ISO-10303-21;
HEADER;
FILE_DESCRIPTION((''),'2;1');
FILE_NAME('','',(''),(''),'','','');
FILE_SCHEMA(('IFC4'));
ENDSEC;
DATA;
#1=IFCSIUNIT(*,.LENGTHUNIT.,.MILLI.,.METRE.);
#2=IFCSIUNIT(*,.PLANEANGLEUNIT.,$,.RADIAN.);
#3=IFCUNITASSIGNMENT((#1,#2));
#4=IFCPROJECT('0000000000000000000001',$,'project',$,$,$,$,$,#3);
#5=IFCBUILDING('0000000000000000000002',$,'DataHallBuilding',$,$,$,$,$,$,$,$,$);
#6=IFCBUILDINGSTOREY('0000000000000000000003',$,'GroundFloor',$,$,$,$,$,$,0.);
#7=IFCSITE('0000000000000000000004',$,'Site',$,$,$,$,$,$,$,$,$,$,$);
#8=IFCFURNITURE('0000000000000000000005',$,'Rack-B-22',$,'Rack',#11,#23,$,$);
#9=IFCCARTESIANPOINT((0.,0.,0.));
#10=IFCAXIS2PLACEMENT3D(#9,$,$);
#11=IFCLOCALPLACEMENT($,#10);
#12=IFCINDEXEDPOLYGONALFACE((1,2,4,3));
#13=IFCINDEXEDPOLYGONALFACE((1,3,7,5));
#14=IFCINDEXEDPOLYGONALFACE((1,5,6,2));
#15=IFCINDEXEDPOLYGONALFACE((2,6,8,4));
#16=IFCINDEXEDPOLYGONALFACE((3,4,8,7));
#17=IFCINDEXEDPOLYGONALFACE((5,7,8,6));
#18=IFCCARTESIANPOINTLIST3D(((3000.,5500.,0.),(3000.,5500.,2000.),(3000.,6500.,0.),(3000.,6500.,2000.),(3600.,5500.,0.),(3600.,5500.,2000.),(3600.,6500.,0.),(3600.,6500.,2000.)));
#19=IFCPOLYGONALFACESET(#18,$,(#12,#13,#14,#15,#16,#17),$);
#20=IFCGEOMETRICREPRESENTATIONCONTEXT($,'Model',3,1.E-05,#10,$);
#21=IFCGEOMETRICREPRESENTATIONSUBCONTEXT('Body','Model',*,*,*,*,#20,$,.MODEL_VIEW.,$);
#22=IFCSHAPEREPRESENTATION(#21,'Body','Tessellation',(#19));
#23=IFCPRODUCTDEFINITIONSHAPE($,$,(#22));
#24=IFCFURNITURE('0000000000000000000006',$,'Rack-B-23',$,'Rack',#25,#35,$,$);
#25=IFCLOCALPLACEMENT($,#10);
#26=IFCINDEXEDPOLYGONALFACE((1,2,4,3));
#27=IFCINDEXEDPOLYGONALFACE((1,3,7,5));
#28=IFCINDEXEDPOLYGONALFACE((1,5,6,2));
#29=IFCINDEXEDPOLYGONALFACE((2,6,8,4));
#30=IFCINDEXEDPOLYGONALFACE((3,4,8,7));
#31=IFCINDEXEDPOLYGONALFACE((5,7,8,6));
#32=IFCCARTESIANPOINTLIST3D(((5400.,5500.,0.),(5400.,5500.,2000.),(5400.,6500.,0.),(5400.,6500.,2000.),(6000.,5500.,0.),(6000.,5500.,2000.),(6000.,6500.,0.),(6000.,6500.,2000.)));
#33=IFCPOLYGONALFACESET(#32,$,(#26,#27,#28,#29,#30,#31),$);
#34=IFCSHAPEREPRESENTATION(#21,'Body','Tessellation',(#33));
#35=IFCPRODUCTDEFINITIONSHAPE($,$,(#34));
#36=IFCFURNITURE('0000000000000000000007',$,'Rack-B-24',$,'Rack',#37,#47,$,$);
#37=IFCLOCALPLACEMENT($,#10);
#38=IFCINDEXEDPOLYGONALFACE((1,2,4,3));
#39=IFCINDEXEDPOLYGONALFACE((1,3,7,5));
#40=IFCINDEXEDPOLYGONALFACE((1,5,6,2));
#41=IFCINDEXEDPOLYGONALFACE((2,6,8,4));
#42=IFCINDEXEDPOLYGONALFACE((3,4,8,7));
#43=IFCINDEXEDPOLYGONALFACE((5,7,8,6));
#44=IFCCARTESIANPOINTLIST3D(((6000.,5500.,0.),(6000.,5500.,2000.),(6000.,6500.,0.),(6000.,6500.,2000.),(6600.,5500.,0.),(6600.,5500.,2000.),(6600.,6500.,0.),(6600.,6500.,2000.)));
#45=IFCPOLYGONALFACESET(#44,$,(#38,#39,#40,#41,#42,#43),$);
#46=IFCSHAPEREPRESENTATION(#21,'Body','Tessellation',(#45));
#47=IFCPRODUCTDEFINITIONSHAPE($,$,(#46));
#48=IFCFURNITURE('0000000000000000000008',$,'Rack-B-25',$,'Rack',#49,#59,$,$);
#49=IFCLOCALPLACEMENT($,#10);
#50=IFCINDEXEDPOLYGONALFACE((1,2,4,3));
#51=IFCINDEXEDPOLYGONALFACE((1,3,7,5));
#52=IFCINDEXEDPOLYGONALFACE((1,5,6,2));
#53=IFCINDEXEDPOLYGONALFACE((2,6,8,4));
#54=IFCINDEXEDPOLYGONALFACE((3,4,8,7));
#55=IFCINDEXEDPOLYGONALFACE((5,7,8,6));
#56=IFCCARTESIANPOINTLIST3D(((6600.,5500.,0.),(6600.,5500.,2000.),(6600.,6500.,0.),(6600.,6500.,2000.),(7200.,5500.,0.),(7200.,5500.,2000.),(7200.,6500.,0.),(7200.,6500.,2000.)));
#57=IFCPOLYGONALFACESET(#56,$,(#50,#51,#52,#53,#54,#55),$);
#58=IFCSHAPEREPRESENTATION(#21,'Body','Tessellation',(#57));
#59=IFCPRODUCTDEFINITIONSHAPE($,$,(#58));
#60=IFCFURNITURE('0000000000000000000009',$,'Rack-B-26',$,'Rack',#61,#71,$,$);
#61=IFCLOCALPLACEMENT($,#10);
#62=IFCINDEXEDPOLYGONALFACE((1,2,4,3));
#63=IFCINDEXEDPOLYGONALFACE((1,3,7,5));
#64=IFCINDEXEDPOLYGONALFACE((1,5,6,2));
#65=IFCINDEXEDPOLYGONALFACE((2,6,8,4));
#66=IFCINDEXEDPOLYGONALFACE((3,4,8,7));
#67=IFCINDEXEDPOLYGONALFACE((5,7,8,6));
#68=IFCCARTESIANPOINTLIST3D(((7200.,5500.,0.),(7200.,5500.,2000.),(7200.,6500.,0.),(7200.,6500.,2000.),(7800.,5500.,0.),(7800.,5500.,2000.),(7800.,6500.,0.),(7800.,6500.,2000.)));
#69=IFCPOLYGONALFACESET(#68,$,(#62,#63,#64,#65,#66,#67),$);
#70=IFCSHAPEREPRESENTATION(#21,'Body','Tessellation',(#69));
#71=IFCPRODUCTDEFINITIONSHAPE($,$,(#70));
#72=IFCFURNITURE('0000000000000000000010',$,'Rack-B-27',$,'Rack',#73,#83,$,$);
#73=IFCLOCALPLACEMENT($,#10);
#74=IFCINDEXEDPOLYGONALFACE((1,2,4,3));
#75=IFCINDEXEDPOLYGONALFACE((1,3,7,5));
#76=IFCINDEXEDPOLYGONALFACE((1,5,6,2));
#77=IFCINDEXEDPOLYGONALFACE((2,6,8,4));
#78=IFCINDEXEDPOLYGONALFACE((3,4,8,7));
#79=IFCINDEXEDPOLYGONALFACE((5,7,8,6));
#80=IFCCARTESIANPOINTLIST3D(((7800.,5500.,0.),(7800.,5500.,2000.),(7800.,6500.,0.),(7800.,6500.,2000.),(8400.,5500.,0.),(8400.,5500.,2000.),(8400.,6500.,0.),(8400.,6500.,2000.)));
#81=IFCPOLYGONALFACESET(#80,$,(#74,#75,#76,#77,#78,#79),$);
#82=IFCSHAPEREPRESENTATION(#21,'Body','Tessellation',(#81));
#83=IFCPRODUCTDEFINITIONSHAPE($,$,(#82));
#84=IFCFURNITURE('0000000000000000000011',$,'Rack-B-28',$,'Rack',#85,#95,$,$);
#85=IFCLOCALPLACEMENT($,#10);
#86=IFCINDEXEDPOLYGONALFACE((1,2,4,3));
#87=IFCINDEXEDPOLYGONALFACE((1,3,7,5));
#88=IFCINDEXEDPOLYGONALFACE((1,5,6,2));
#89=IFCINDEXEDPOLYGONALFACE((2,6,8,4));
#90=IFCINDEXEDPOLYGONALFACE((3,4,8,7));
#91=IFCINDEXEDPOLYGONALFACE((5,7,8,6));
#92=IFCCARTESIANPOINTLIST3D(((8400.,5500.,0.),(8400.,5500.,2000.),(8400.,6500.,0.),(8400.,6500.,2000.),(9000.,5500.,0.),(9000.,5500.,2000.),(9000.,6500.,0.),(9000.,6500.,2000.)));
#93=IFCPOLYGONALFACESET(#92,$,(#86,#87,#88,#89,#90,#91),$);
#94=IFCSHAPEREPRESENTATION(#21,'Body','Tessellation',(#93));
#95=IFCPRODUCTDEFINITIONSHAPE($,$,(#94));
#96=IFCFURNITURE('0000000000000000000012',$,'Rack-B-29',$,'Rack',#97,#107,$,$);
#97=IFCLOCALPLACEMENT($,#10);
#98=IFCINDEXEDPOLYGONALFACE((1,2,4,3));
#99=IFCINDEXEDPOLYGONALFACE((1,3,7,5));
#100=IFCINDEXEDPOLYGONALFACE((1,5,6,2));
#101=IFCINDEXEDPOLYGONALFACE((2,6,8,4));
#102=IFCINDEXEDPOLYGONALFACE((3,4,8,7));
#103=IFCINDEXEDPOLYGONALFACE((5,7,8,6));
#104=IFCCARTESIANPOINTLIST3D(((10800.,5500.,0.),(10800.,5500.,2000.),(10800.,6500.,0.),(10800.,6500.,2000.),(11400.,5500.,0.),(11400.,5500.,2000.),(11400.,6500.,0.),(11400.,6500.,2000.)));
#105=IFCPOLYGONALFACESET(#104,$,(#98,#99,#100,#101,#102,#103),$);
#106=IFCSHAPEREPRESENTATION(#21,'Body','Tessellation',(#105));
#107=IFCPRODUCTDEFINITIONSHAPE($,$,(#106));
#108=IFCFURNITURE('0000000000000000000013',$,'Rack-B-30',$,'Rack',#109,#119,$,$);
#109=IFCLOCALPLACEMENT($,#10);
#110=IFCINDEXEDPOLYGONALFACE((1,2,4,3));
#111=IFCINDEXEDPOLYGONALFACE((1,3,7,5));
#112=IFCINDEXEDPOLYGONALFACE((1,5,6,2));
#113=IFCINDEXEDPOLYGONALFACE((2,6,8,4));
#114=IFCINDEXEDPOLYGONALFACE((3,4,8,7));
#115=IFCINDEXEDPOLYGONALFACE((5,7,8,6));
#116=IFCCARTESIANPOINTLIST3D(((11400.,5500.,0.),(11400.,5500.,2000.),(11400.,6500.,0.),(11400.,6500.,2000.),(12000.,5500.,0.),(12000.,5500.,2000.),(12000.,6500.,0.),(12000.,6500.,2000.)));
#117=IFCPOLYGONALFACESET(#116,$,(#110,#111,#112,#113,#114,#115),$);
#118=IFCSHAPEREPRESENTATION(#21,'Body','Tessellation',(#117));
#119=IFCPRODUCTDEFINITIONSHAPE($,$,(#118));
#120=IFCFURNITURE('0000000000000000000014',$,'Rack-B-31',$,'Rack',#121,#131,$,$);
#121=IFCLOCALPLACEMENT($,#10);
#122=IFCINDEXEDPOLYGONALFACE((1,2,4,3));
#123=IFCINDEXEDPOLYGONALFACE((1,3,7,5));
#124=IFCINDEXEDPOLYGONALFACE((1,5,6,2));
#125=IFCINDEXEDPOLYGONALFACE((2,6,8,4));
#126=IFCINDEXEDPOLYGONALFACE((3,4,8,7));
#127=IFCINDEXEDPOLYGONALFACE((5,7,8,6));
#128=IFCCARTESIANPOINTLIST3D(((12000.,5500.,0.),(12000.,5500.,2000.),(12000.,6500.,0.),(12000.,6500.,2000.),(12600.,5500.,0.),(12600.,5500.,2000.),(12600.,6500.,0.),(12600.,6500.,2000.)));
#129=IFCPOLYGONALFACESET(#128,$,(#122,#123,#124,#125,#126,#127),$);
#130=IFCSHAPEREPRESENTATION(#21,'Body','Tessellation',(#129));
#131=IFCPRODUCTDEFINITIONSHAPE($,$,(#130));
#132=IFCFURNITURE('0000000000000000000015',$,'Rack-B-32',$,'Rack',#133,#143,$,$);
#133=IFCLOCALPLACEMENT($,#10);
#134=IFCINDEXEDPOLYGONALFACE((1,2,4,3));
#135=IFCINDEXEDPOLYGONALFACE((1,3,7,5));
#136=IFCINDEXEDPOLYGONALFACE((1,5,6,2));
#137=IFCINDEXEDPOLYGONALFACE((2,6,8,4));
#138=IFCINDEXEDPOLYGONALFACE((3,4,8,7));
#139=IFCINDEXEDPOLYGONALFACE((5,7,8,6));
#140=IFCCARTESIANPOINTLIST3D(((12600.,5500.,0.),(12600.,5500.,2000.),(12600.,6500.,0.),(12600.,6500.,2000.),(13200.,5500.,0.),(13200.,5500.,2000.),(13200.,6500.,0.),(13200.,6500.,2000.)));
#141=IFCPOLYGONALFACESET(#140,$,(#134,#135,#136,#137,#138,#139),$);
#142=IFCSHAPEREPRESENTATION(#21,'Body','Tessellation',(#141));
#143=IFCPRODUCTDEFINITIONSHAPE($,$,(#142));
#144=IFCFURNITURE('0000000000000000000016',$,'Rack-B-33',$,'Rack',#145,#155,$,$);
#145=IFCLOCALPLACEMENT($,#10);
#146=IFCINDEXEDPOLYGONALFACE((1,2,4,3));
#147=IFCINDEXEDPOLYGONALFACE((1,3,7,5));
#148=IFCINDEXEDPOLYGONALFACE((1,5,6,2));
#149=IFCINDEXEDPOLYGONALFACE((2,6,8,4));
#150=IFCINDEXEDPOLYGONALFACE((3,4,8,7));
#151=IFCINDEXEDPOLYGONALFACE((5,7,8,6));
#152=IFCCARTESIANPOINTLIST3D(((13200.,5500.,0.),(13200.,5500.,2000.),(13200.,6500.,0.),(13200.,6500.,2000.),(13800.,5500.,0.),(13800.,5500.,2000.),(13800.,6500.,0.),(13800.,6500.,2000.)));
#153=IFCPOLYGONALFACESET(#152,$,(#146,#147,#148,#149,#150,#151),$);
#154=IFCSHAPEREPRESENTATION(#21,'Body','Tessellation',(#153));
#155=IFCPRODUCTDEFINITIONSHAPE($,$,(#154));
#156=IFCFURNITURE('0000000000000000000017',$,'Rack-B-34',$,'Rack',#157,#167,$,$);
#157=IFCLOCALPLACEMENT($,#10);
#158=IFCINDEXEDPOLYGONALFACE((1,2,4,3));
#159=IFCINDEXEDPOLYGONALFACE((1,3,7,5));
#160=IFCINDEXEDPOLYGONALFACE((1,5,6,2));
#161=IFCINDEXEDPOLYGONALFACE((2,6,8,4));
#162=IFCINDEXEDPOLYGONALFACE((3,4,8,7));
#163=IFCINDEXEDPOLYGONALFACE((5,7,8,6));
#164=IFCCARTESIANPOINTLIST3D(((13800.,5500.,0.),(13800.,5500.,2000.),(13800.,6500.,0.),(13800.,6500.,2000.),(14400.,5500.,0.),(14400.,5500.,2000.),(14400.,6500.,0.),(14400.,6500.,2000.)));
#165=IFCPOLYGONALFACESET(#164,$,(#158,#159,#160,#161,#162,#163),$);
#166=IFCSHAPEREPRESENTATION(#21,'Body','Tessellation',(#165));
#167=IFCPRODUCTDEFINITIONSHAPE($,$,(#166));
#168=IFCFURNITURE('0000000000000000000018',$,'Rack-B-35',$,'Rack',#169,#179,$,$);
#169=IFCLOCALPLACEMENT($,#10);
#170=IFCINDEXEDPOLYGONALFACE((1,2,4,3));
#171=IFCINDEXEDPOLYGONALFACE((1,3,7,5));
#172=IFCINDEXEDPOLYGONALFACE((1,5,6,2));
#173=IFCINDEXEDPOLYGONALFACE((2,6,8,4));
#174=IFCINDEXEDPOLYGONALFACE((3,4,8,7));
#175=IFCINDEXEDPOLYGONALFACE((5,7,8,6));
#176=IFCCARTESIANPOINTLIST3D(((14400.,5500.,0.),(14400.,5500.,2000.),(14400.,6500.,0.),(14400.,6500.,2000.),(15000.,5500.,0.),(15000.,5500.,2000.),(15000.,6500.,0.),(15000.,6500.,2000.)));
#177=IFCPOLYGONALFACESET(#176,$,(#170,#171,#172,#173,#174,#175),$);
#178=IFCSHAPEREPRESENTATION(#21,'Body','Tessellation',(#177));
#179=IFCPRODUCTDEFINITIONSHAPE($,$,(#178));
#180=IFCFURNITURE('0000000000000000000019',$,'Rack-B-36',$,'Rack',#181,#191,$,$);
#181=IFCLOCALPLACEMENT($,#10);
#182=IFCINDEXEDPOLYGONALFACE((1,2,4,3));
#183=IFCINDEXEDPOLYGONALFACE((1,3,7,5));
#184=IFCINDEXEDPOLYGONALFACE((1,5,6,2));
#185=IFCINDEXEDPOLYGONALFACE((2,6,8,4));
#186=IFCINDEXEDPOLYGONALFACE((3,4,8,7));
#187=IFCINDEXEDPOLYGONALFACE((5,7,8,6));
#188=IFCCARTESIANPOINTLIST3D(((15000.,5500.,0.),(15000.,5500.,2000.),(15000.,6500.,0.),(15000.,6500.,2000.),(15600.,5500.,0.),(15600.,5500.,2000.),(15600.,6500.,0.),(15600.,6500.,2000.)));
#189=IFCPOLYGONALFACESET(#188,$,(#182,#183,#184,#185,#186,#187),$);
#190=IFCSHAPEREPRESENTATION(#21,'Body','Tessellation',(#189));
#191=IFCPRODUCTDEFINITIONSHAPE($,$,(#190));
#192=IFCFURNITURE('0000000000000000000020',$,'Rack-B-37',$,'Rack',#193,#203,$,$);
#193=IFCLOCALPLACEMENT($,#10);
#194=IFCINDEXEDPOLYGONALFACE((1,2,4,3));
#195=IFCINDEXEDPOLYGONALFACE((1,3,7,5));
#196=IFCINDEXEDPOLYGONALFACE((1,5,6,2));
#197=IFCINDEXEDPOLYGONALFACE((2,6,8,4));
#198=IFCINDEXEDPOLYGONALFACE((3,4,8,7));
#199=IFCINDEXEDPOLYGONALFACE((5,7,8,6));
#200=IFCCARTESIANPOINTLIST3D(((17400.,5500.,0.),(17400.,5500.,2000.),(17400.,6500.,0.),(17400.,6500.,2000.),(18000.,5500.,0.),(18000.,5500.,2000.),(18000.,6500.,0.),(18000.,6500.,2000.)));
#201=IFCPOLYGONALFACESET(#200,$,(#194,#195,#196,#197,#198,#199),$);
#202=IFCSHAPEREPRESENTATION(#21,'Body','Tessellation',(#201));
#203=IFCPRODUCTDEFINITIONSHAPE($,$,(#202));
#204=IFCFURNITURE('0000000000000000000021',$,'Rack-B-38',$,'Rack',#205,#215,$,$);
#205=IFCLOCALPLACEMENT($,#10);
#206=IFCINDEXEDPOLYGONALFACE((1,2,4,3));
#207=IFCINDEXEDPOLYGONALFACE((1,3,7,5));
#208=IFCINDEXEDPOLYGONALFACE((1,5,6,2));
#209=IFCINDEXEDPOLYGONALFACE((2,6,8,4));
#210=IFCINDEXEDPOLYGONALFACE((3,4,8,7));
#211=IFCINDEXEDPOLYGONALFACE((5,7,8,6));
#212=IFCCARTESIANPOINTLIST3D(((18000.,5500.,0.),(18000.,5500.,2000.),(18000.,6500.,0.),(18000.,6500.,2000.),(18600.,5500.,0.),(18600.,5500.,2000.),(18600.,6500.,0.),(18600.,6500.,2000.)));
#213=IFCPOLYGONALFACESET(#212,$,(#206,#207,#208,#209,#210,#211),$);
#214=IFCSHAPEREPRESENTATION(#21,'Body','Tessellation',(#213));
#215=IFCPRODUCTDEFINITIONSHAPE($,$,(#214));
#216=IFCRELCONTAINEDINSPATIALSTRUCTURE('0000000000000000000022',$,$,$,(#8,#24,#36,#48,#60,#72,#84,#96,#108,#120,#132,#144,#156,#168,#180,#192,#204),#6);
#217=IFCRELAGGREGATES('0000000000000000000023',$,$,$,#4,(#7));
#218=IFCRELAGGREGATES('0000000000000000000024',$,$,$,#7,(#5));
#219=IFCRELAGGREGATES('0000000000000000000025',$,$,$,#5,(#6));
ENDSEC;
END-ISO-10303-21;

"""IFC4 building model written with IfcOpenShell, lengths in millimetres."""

from ifc_helpers import new_model, si_unit, frame, origin, place, context, subcontext, project, spatial, rectangle, extrude, element, save


model = new_model("IFC4")

# Units and contexts
model_context = context("Model", 3, precision=1e-05, world=origin())
body_context = subcontext(model_context, "Body", "Model", "MODEL_VIEW")
ifc_project = project(units=[si_unit("LENGTHUNIT", "METRE", prefix="MILLI"), si_unit("PLANEANGLEUNIT", "RADIAN")])

# Site, building, storey
site = spatial("IfcSite", under=ifc_project, Name="Site")
building = spatial("IfcBuilding", under=site, Name="DataHallBuilding")
storey = spatial("IfcBuildingStorey", under=building, Name="GroundFloor", Elevation=0.0)

# Furniture
furniture_1_placement = place(None, origin())
element("IfcFurniture", 1, at=furniture_1_placement, inside=storey, Name="Rack-B-22", ObjectType="Rack", context=body_context, shape_type="SweptSolid", body=[
    extrude(rectangle(XDim=600.0, YDim=1000.0), frame((3300.0, 6000.0, 0.0), z_axis=(0.0, 0.0, 1.0), x_axis=(1.0, 0.0, 0.0)), (0.0, 0.0, 1.0), 2000.0),
])
furniture_2_placement = place(None, origin())
element("IfcFurniture", 2, at=furniture_2_placement, inside=storey, Name="Rack-B-23", ObjectType="Rack", context=body_context, shape_type="SweptSolid", body=[
    extrude(rectangle(XDim=600.0, YDim=1000.0), frame((5700.0, 6000.0, 0.0), z_axis=(0.0, 0.0, 1.0), x_axis=(1.0, 0.0, 0.0)), (0.0, 0.0, 1.0), 2000.0),
])
furniture_3_placement = place(None, origin())
element("IfcFurniture", 3, at=furniture_3_placement, inside=storey, Name="Rack-B-24", ObjectType="Rack", context=body_context, shape_type="SweptSolid", body=[
    extrude(rectangle(XDim=600.0, YDim=1000.0), frame((6300.0, 6000.0, 0.0), z_axis=(0.0, 0.0, 1.0), x_axis=(1.0, 0.0, 0.0)), (0.0, 0.0, 1.0), 2000.0),
])
furniture_4_placement = place(None, origin())
element("IfcFurniture", 4, at=furniture_4_placement, inside=storey, Name="Rack-B-25", ObjectType="Rack", context=body_context, shape_type="SweptSolid", body=[
    extrude(rectangle(XDim=600.0, YDim=1000.0), frame((6900.0, 6000.0, 0.0), z_axis=(0.0, 0.0, 1.0), x_axis=(1.0, 0.0, 0.0)), (0.0, 0.0, 1.0), 2000.0),
])
furniture_5_placement = place(None, origin())
element("IfcFurniture", 5, at=furniture_5_placement, inside=storey, Name="Rack-B-26", ObjectType="Rack", context=body_context, shape_type="SweptSolid", body=[
    extrude(rectangle(XDim=600.0, YDim=1000.0), frame((7500.0, 6000.0, 0.0), z_axis=(0.0, 0.0, 1.0), x_axis=(1.0, 0.0, 0.0)), (0.0, 0.0, 1.0), 2000.0),
])
furniture_6_placement = place(None, origin())
element("IfcFurniture", 6, at=furniture_6_placement, inside=storey, Name="Rack-B-27", ObjectType="Rack", context=body_context, shape_type="SweptSolid", body=[
    extrude(rectangle(XDim=600.0, YDim=1000.0), frame((8100.0, 6000.0, 0.0), z_axis=(0.0, 0.0, 1.0), x_axis=(1.0, 0.0, 0.0)), (0.0, 0.0, 1.0), 2000.0),
])
furniture_7_placement = place(None, origin())
element("IfcFurniture", 7, at=furniture_7_placement, inside=storey, Name="Rack-B-28", ObjectType="Rack", context=body_context, shape_type="SweptSolid", body=[
    extrude(rectangle(XDim=600.0, YDim=1000.0), frame((8700.0, 6000.0, 0.0), z_axis=(0.0, 0.0, 1.0), x_axis=(1.0, 0.0, 0.0)), (0.0, 0.0, 1.0), 2000.0),
])
furniture_8_placement = place(None, origin())
element("IfcFurniture", 8, at=furniture_8_placement, inside=storey, Name="Rack-B-29", ObjectType="Rack", context=body_context, shape_type="SweptSolid", body=[
    extrude(rectangle(XDim=600.0, YDim=1000.0), frame((11100.0, 6000.0, 0.0), z_axis=(0.0, 0.0, 1.0), x_axis=(1.0, 0.0, 0.0)), (0.0, 0.0, 1.0), 2000.0),
])
furniture_9_placement = place(None, origin())
element("IfcFurniture", 9, at=furniture_9_placement, inside=storey, Name="Rack-B-30", ObjectType="Rack", context=body_context, shape_type="SweptSolid", body=[
    extrude(rectangle(XDim=600.0, YDim=1000.0), frame((11700.0, 6000.0, 0.0), z_axis=(0.0, 0.0, 1.0), x_axis=(1.0, 0.0, 0.0)), (0.0, 0.0, 1.0), 2000.0),
])
furniture_10_placement = place(None, origin())
element("IfcFurniture", 10, at=furniture_10_placement, inside=storey, Name="Rack-B-31", ObjectType="Rack", context=body_context, shape_type="SweptSolid", body=[
    extrude(rectangle(XDim=600.0, YDim=1000.0), frame((12300.0, 6000.0, 0.0), z_axis=(0.0, 0.0, 1.0), x_axis=(1.0, 0.0, 0.0)), (0.0, 0.0, 1.0), 2000.0),
])
furniture_11_placement = place(None, origin())
element("IfcFurniture", 11, at=furniture_11_placement, inside=storey, Name="Rack-B-32", ObjectType="Rack", context=body_context, shape_type="SweptSolid", body=[
    extrude(rectangle(XDim=600.0, YDim=1000.0), frame((12900.0, 6000.0, 0.0), z_axis=(0.0, 0.0, 1.0), x_axis=(1.0, 0.0, 0.0)), (0.0, 0.0, 1.0), 2000.0),
])
furniture_12_placement = place(None, origin())
element("IfcFurniture", 12, at=furniture_12_placement, inside=storey, Name="Rack-B-33", ObjectType="Rack", context=body_context, shape_type="SweptSolid", body=[
    extrude(rectangle(XDim=600.0, YDim=1000.0), frame((13500.0, 6000.0, 0.0), z_axis=(0.0, 0.0, 1.0), x_axis=(1.0, 0.0, 0.0)), (0.0, 0.0, 1.0), 2000.0),
])
furniture_13_placement = place(None, origin())
element("IfcFurniture", 13, at=furniture_13_placement, inside=storey, Name="Rack-B-34", ObjectType="Rack", context=body_context, shape_type="SweptSolid", body=[
    extrude(rectangle(XDim=600.0, YDim=1000.0), frame((14100.0, 6000.0, 0.0), z_axis=(0.0, 0.0, 1.0), x_axis=(1.0, 0.0, 0.0)), (0.0, 0.0, 1.0), 2000.0),
])
furniture_14_placement = place(None, origin())
element("IfcFurniture", 14, at=furniture_14_placement, inside=storey, Name="Rack-B-35", ObjectType="Rack", context=body_context, shape_type="SweptSolid", body=[
    extrude(rectangle(XDim=600.0, YDim=1000.0), frame((14700.0, 6000.0, 0.0), z_axis=(0.0, 0.0, 1.0), x_axis=(1.0, 0.0, 0.0)), (0.0, 0.0, 1.0), 2000.0),
])
furniture_15_placement = place(None, origin())
element("IfcFurniture", 15, at=furniture_15_placement, inside=storey, Name="Rack-B-36", ObjectType="Rack", context=body_context, shape_type="SweptSolid", body=[
    extrude(rectangle(XDim=600.0, YDim=1000.0), frame((15300.0, 6000.0, 0.0), z_axis=(0.0, 0.0, 1.0), x_axis=(1.0, 0.0, 0.0)), (0.0, 0.0, 1.0), 2000.0),
])
furniture_16_placement = place(None, origin())
element("IfcFurniture", 16, at=furniture_16_placement, inside=storey, Name="Rack-B-37", ObjectType="Rack", context=body_context, shape_type="SweptSolid", body=[
    extrude(rectangle(XDim=600.0, YDim=1000.0), frame((17700.0, 6000.0, 0.0), z_axis=(0.0, 0.0, 1.0), x_axis=(1.0, 0.0, 0.0)), (0.0, 0.0, 1.0), 2000.0),
])
furniture_17_placement = place(None, origin())
element("IfcFurniture", 17, at=furniture_17_placement, inside=storey, Name="Rack-B-38", ObjectType="Rack", context=body_context, shape_type="SweptSolid", body=[
    extrude(rectangle(XDim=600.0, YDim=1000.0), frame((18300.0, 6000.0, 0.0), z_axis=(0.0, 0.0, 1.0), x_axis=(1.0, 0.0, 0.0)), (0.0, 0.0, 1.0), 2000.0),
])

save(model, "model.ifc")
